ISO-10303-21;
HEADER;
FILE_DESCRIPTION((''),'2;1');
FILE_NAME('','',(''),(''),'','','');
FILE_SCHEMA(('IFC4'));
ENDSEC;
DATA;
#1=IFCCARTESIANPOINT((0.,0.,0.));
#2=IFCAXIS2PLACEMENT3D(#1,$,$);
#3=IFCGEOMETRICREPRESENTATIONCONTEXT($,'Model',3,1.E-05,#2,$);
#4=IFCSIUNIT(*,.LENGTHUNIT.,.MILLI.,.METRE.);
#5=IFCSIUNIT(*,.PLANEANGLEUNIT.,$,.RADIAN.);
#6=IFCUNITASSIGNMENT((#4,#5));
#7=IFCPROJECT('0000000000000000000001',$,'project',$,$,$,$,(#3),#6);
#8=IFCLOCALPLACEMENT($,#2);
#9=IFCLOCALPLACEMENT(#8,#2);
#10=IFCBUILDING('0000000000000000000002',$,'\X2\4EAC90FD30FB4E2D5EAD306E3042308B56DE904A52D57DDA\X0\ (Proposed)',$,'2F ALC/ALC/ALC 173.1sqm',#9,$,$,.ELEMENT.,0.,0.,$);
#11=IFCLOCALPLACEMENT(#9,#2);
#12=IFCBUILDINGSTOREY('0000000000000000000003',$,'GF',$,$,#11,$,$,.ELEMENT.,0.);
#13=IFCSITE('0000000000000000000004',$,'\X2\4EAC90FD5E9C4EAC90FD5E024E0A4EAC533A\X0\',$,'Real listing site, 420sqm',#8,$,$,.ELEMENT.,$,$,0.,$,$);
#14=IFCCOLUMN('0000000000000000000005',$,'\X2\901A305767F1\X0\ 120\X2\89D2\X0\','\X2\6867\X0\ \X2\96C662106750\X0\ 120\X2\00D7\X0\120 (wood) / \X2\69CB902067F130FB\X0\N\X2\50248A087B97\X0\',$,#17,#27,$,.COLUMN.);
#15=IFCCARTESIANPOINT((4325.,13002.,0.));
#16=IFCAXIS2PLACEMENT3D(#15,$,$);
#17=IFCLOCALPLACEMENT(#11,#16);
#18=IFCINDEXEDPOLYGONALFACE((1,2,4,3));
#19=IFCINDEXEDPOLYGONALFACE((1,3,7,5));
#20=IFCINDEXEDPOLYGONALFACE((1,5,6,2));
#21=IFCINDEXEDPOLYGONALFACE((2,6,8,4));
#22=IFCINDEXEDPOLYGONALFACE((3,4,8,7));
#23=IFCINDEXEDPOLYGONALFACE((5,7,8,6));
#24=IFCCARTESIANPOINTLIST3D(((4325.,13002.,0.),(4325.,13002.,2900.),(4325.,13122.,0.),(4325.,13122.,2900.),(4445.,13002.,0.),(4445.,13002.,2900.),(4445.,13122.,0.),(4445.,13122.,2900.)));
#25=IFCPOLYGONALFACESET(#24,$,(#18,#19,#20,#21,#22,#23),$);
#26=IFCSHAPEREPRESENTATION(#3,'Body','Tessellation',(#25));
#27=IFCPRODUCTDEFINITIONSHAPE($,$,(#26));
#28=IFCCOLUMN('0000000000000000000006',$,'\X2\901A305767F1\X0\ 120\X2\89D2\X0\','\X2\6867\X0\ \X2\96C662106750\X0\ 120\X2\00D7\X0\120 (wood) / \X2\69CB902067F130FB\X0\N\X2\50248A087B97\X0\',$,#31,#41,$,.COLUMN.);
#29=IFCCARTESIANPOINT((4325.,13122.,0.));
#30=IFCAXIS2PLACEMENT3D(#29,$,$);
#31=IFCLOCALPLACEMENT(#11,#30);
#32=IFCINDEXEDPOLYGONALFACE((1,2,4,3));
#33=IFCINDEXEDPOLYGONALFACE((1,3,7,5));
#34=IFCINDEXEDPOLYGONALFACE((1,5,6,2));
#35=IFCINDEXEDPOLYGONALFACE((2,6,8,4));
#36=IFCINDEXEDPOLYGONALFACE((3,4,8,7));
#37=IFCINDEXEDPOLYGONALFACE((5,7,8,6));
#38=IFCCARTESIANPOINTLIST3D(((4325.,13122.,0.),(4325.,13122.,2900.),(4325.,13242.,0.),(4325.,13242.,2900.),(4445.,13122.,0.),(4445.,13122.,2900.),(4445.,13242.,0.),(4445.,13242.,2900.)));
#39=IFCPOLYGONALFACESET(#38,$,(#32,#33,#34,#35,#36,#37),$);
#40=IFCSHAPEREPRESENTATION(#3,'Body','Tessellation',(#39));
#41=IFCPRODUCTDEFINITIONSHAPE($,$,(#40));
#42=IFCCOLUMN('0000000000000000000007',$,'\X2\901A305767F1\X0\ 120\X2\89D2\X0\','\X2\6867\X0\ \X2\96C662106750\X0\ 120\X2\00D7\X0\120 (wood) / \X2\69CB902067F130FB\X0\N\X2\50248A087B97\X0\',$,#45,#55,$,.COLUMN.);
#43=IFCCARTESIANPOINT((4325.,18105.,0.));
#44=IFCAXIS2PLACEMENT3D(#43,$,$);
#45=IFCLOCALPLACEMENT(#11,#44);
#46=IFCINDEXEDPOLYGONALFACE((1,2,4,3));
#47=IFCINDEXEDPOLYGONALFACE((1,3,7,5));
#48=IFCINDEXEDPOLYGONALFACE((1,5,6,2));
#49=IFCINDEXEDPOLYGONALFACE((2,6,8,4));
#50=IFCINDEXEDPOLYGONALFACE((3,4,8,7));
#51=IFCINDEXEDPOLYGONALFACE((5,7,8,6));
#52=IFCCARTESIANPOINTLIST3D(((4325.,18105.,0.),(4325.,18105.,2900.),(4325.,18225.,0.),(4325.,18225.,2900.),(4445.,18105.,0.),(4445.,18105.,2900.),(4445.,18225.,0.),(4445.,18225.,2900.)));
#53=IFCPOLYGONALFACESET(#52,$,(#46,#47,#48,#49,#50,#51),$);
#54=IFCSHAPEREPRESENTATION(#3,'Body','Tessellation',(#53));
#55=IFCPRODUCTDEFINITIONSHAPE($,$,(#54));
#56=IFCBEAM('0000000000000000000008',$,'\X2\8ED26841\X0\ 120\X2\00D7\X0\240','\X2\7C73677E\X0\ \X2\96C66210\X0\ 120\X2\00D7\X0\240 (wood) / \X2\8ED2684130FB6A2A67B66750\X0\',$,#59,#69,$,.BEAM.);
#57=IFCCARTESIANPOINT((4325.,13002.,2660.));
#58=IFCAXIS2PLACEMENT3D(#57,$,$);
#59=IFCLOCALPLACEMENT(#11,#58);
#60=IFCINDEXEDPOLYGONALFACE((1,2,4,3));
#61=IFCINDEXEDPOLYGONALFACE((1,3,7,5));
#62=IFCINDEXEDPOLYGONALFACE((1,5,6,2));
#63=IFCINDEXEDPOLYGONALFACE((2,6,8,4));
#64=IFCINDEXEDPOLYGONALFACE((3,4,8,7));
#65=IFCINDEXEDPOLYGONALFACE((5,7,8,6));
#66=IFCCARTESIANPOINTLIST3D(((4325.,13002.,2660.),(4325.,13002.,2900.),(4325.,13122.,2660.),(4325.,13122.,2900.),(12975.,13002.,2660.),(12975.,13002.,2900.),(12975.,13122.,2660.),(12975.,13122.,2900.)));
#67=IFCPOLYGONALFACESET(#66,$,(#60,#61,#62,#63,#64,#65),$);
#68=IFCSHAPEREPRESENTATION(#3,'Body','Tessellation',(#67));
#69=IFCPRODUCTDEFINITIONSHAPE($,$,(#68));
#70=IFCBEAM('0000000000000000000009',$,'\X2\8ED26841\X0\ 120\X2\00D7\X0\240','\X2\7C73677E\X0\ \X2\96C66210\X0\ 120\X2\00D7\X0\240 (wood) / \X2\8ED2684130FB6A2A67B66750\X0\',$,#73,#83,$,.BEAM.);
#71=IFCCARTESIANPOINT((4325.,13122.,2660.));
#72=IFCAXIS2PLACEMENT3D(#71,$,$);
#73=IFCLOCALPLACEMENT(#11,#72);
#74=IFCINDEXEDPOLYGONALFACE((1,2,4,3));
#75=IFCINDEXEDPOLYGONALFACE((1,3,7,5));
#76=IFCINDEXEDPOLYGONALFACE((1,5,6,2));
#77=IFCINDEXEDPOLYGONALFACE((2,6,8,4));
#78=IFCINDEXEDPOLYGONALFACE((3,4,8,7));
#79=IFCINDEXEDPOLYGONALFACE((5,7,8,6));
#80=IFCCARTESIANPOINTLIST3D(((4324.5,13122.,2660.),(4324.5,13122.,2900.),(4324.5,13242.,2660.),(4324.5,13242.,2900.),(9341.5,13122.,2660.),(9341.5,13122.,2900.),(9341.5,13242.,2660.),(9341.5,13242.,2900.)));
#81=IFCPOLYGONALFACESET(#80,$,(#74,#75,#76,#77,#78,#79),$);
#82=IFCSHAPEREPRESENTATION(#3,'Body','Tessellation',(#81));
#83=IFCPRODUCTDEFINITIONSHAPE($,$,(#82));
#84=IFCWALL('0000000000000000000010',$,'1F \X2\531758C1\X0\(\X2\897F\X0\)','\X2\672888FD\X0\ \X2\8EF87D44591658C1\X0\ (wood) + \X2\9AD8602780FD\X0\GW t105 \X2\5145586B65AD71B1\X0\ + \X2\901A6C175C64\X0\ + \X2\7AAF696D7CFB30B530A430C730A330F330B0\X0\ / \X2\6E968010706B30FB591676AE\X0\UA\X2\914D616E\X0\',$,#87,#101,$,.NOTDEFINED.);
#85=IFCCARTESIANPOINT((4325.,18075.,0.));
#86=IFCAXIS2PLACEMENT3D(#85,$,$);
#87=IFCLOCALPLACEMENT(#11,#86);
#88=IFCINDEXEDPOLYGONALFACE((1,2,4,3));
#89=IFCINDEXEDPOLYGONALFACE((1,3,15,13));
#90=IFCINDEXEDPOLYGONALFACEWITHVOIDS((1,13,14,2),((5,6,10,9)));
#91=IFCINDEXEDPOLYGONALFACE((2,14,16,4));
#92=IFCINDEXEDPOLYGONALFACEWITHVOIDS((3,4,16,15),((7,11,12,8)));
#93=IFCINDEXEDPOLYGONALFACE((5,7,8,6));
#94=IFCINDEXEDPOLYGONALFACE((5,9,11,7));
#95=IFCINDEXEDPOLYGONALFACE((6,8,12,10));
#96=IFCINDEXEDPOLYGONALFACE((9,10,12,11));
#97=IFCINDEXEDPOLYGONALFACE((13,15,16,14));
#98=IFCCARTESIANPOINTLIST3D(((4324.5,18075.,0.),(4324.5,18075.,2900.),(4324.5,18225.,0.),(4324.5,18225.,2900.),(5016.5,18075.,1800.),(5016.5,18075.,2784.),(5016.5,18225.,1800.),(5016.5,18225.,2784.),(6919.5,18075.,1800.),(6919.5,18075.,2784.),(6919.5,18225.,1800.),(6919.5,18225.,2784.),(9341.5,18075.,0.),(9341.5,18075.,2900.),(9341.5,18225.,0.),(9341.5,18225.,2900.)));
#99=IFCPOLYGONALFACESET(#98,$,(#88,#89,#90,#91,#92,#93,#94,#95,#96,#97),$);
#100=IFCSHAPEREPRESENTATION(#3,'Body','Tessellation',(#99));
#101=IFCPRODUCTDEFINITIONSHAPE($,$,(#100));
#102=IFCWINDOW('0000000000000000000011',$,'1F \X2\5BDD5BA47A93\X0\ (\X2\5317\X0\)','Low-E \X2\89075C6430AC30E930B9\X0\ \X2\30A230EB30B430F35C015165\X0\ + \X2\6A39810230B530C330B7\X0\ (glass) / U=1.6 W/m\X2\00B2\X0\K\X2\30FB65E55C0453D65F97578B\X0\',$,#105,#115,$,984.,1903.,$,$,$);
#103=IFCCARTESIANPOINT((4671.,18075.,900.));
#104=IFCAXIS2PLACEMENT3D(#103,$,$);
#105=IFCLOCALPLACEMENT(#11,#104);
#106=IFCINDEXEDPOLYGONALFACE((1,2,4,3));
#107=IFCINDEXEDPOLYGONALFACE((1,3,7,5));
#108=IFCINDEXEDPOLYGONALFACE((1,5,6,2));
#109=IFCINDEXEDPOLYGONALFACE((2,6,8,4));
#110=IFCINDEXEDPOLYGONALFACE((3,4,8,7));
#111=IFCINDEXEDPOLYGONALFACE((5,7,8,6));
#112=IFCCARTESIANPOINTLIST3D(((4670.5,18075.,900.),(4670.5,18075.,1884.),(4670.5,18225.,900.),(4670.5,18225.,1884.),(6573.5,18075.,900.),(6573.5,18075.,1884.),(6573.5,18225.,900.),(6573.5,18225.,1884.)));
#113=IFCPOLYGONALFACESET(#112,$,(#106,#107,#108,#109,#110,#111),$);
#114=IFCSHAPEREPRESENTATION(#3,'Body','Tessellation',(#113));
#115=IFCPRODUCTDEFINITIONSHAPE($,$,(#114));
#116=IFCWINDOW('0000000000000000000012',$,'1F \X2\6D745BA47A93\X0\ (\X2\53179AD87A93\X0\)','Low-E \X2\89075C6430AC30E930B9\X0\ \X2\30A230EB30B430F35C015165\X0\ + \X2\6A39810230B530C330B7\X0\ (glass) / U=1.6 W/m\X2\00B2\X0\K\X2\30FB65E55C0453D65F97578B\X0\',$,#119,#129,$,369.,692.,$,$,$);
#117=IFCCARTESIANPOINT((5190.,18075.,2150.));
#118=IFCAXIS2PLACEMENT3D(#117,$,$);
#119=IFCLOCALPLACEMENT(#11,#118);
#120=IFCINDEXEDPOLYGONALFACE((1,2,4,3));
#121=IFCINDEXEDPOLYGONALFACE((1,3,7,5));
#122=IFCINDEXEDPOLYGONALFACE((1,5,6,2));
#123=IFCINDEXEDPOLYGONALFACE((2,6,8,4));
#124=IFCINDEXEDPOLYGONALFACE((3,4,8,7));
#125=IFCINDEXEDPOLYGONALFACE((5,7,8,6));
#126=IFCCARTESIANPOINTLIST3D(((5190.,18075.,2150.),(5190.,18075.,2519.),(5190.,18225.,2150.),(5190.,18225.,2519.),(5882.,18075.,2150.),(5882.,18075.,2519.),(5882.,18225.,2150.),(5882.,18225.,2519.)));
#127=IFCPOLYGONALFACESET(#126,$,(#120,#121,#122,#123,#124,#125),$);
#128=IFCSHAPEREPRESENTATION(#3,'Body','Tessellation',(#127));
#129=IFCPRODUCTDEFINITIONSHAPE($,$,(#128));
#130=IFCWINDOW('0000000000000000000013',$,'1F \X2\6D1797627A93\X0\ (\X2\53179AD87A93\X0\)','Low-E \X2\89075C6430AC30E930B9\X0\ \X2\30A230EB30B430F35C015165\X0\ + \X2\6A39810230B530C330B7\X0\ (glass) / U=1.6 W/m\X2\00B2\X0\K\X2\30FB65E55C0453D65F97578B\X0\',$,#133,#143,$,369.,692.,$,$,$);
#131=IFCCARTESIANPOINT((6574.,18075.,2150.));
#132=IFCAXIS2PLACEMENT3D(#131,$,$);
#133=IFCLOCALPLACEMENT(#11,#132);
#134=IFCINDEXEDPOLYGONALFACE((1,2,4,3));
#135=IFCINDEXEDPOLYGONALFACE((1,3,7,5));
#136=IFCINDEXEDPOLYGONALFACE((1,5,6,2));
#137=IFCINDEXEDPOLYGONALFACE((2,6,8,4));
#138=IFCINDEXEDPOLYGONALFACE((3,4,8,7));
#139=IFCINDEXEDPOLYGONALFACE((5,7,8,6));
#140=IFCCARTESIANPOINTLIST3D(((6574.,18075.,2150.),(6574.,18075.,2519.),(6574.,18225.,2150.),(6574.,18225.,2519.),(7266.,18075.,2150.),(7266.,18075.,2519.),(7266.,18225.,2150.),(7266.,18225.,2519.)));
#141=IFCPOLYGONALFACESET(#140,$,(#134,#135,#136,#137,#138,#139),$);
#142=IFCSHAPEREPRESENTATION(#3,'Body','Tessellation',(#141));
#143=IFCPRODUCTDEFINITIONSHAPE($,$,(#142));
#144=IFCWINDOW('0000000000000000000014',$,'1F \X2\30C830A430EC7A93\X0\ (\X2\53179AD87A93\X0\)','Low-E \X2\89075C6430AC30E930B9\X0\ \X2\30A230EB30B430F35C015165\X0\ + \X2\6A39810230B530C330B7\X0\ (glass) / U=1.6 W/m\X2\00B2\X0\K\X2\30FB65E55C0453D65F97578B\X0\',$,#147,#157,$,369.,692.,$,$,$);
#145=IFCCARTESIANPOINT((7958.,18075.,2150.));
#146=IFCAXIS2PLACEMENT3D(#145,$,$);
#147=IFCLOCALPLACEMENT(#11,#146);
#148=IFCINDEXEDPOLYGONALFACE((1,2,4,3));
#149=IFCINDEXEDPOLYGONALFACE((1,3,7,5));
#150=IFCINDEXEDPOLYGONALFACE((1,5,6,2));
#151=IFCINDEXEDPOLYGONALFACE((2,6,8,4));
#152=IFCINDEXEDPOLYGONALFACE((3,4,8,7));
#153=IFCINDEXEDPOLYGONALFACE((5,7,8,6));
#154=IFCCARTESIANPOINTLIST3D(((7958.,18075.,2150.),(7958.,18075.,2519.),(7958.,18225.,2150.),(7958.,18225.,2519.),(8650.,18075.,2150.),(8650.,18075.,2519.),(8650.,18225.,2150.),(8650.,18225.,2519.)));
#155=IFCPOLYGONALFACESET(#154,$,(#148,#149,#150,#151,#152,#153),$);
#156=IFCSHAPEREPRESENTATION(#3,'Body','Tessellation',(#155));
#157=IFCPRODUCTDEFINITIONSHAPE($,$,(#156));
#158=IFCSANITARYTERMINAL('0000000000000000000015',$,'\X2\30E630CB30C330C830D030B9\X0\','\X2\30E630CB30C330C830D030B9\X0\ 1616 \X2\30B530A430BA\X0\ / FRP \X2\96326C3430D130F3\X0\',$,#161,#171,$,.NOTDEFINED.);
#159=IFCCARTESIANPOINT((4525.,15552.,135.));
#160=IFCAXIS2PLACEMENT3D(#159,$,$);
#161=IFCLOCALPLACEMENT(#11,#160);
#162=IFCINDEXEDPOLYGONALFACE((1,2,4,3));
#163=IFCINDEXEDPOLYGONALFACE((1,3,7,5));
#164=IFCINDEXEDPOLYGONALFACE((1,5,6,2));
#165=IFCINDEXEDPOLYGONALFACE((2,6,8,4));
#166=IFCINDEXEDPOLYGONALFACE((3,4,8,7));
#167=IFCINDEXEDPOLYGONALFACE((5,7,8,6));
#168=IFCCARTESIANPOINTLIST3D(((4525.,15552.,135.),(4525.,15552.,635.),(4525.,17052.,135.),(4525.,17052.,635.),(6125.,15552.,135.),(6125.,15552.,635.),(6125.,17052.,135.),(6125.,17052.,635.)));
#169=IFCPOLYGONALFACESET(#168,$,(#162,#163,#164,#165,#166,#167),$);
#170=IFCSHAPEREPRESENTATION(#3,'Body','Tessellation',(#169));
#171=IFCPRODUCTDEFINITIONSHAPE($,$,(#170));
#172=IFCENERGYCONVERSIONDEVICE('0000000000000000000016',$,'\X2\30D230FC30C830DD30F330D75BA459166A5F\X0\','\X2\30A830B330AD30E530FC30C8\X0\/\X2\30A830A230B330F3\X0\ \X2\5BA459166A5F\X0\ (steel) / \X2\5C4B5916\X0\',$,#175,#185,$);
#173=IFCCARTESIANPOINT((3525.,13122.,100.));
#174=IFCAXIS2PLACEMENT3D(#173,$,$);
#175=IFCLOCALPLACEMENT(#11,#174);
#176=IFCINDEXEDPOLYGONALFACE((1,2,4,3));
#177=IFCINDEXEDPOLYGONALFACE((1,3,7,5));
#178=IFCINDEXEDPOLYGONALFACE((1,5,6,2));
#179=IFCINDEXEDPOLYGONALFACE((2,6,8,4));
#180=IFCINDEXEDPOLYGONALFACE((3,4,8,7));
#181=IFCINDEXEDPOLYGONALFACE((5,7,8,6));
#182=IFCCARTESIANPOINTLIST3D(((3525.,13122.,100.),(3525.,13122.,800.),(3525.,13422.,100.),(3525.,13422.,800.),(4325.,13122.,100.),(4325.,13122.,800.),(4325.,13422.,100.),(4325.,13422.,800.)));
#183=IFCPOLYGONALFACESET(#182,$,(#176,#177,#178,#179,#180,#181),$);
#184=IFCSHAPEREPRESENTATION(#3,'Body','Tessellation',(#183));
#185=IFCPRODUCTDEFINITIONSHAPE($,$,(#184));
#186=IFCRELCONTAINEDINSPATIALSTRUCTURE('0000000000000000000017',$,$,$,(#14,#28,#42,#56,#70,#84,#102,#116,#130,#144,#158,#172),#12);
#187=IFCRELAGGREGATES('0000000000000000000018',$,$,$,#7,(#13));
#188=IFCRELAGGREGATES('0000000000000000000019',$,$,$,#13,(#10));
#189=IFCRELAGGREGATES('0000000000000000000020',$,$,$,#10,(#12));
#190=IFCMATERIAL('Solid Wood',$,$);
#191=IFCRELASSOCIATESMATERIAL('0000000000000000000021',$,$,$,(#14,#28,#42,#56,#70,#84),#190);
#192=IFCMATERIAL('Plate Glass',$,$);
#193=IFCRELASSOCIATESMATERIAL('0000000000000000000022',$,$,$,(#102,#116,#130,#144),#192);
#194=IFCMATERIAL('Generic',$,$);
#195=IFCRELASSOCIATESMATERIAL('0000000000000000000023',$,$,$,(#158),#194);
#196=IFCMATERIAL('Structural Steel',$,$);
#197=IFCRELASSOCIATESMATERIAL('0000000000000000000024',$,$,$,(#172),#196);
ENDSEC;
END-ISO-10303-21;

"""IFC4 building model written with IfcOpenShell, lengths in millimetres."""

from ifc_helpers import new_model, si_unit, frame, frame_2d, origin, place, context, project, spatial, rectangle, extrude, material, element, fill, save


model = new_model("IFC4")

# Units and contexts
model_context = context("Model", 3, precision=1e-05, world=origin())
ifc_project = project(units=[si_unit("LENGTHUNIT", "METRE", prefix="MILLI"), si_unit("PLANEANGLEUNIT", "RADIAN")], contexts=[model_context])

# Site, building, storey
site_placement = place(None, origin())
site = spatial("IfcSite", under=ifc_project, at=site_placement, Name="京都府京都市上京区", ObjectType="Real listing site, 420sqm", CompositionType="ELEMENT", RefElevation=0.0)
building_placement = place(site_placement, origin())
building = spatial("IfcBuilding", under=site, at=building_placement, Name="京都・中庭のある回遊動線 (Proposed)", ObjectType="2F ALC/ALC/ALC 173.1sqm", CompositionType="ELEMENT", ElevationOfRefHeight=0.0, ElevationOfTerrain=0.0)
storey_placement = place(building_placement, origin())
storey = spatial("IfcBuildingStorey", under=building, at=storey_placement, Name="GF", CompositionType="ELEMENT", Elevation=0.0)

# Columns
ifc_material_1 = material(Name="Solid Wood")
column_1_placement = place(storey_placement, frame((4325.0, 13002.0, 0.0)))
element("IfcColumn", 1, at=column_1_placement, inside=storey, material=ifc_material_1, Name="通し柱 120角", Description="桧 集成材 120×120 (wood) / 構造柱・N値計算", PredefinedType="COLUMN", context=model_context, shape_type="SweptSolid", body=[
    extrude(rectangle(XDim=120.0, YDim=120.0, at=frame_2d((60.0, 60.0))), frame((4325.0, 13002.0, 0.0)), (0.0, 0.0, 1.0), 2900.0),
])
column_2_placement = place(storey_placement, frame((4325.0, 13122.0, 0.0)))
element("IfcColumn", 2, at=column_2_placement, inside=storey, material=ifc_material_1, Name="通し柱 120角", Description="桧 集成材 120×120 (wood) / 構造柱・N値計算", PredefinedType="COLUMN", context=model_context, shape_type="SweptSolid", body=[
    extrude(rectangle(XDim=120.0, YDim=120.0, at=frame_2d((60.0, 60.0))), frame((4325.0, 13122.0, 0.0)), (0.0, 0.0, 1.0), 2900.0),
])
column_3_placement = place(storey_placement, frame((4325.0, 18105.0, 0.0)))
element("IfcColumn", 3, at=column_3_placement, inside=storey, material=ifc_material_1, Name="通し柱 120角", Description="桧 集成材 120×120 (wood) / 構造柱・N値計算", PredefinedType="COLUMN", context=model_context, shape_type="SweptSolid", body=[
    extrude(rectangle(XDim=120.0, YDim=120.0, at=frame_2d((60.0, 60.0))), frame((4325.0, 18105.0, 0.0)), (0.0, 0.0, 1.0), 2900.0),
])

# Beams
beam_1_placement = place(storey_placement, frame((4325.0, 13002.0, 2660.0)))
element("IfcBeam", 4, at=beam_1_placement, inside=storey, material=ifc_material_1, Name="軒桁 120×240", Description="米松 集成 120×240 (wood) / 軒桁・横架材", PredefinedType="BEAM", context=model_context, shape_type="SweptSolid", body=[
    extrude(rectangle(XDim=8650.0, YDim=120.0, at=frame_2d((4325.0, 60.0))), frame((4325.0, 13002.0, 2660.0)), (0.0, 0.0, 1.0), 240.0),
])
beam_2_placement = place(storey_placement, frame((4325.0, 13122.0, 2660.0)))
element("IfcBeam", 5, at=beam_2_placement, inside=storey, material=ifc_material_1, Name="軒桁 120×240", Description="米松 集成 120×240 (wood) / 軒桁・横架材", PredefinedType="BEAM", context=model_context, shape_type="SweptSolid", body=[
    extrude(rectangle(XDim=5017.0, YDim=120.0, at=frame_2d((2508.0, 60.0))), frame((4325.0, 13122.0, 2660.0)), (0.0, 0.0, 1.0), 240.0),
])

# Wall, openings, windows
wall_1_placement = place(storey_placement, frame((4325.0, 18075.0, 0.0)))
wall_1 = element("IfcWall", 6, at=wall_1_placement, inside=storey, material=ifc_material_1, Name="1F 北壁(西)", Description="木製 軸組外壁 (wood) + 高性能GW t105 充填断熱 + 通気層 + 窯業系サイディング / 準耐火・外皮UA配慮", PredefinedType="NOTDEFINED", context=model_context, shape_type="SweptSolid", body=[
    extrude(rectangle(XDim=5017.0, YDim=150.0, at=frame_2d((2508.0, 75.0))), frame((4325.0, 18075.0, 0.0)), (0.0, 0.0, 1.0), 2900.0),
])
opening_1_placement = place(storey_placement, frame((4671.0, 18075.0, 900.0)))
opening_1 = element("IfcOpeningElement", 7, at=opening_1_placement, cuts=wall_1, PredefinedType="NOTDEFINED", context=model_context, shape_type="SweptSolid", body=[
    extrude(rectangle(XDim=1903.0, YDim=150.0, at=frame_2d((951.0, 75.0))), frame((4671.0, 18075.0, 900.0)), (0.0, 0.0, 1.0), 984.0),
])
opening_2_placement = place(storey_placement, frame((5190.0, 18075.0, 2150.0)))
opening_2 = element("IfcOpeningElement", 8, at=opening_2_placement, cuts=wall_1, PredefinedType="NOTDEFINED", context=model_context, shape_type="SweptSolid", body=[
    extrude(rectangle(XDim=692.0, YDim=150.0, at=frame_2d((346.0, 75.0))), frame((5190.0, 18075.0, 2150.0)), (0.0, 0.0, 1.0), 369.0),
])
opening_3_placement = place(storey_placement, frame((6574.0, 18075.0, 2150.0)))
opening_3 = element("IfcOpeningElement", 9, at=opening_3_placement, cuts=wall_1, PredefinedType="NOTDEFINED", context=model_context, shape_type="SweptSolid", body=[
    extrude(rectangle(XDim=692.0, YDim=150.0, at=frame_2d((346.0, 75.0))), frame((6574.0, 18075.0, 2150.0)), (0.0, 0.0, 1.0), 369.0),
])
opening_4_placement = place(storey_placement, frame((7958.0, 18075.0, 2150.0)))
opening_4 = element("IfcOpeningElement", 10, at=opening_4_placement, cuts=wall_1, PredefinedType="NOTDEFINED", context=model_context, shape_type="SweptSolid", body=[
    extrude(rectangle(XDim=692.0, YDim=150.0, at=frame_2d((346.0, 75.0))), frame((7958.0, 18075.0, 2150.0)), (0.0, 0.0, 1.0), 369.0),
])
ifc_material_2 = material(Name="Plate Glass")
window_1_placement = place(storey_placement, frame((4671.0, 18075.0, 900.0)))
window_1 = element("IfcWindow", 11, at=window_1_placement, inside=storey, material=ifc_material_2, Name="1F 寝室窓 (北)", Description="Low-E 複層ガラス アルゴン封入 + 樹脂サッシ (glass) / U=1.6 W/m²K・日射取得型", OverallHeight=984.0, OverallWidth=1903.0, context=model_context, shape_type="SweptSolid", body=[
    extrude(rectangle(XDim=1903.0, YDim=150.0, at=frame_2d((951.0, 75.0))), frame((4671.0, 18075.0, 900.0)), (0.0, 0.0, 1.0), 984.0),
])
fill(opening_1, window_1)
window_2_placement = place(storey_placement, frame((5190.0, 18075.0, 2150.0)))
window_2 = element("IfcWindow", 12, at=window_2_placement, inside=storey, material=ifc_material_2, Name="1F 浴室窓 (北高窓)", Description="Low-E 複層ガラス アルゴン封入 + 樹脂サッシ (glass) / U=1.6 W/m²K・日射取得型", OverallHeight=369.0, OverallWidth=692.0, context=model_context, shape_type="SweptSolid", body=[
    extrude(rectangle(XDim=692.0, YDim=150.0, at=frame_2d((346.0, 75.0))), frame((5190.0, 18075.0, 2150.0)), (0.0, 0.0, 1.0), 369.0),
])
fill(opening_2, window_2)
window_3_placement = place(storey_placement, frame((6574.0, 18075.0, 2150.0)))
window_3 = element("IfcWindow", 13, at=window_3_placement, inside=storey, material=ifc_material_2, Name="1F 洗面窓 (北高窓)", Description="Low-E 複層ガラス アルゴン封入 + 樹脂サッシ (glass) / U=1.6 W/m²K・日射取得型", OverallHeight=369.0, OverallWidth=692.0, context=model_context, shape_type="SweptSolid", body=[
    extrude(rectangle(XDim=692.0, YDim=150.0, at=frame_2d((346.0, 75.0))), frame((6574.0, 18075.0, 2150.0)), (0.0, 0.0, 1.0), 369.0),
])
fill(opening_3, window_3)
window_4_placement = place(storey_placement, frame((7958.0, 18075.0, 2150.0)))
window_4 = element("IfcWindow", 14, at=window_4_placement, inside=storey, material=ifc_material_2, Name="1F トイレ窓 (北高窓)", Description="Low-E 複層ガラス アルゴン封入 + 樹脂サッシ (glass) / U=1.6 W/m²K・日射取得型", OverallHeight=369.0, OverallWidth=692.0, context=model_context, shape_type="SweptSolid", body=[
    extrude(rectangle(XDim=692.0, YDim=150.0, at=frame_2d((346.0, 75.0))), frame((7958.0, 18075.0, 2150.0)), (0.0, 0.0, 1.0), 369.0),
])
fill(opening_4, window_4)

# Shared definitions
ifc_material_3 = material(Name="Generic")

# Sanitary terminal
sanitary_terminal_placement = place(storey_placement, frame((4525.0, 15552.0, 135.0)))
element("IfcSanitaryTerminal", 15, at=sanitary_terminal_placement, inside=storey, material=ifc_material_3, Name="ユニットバス", Description="ユニットバス 1616 サイズ / FRP 防水パン", PredefinedType="NOTDEFINED", context=model_context, shape_type="SweptSolid", body=[
    extrude(rectangle(XDim=1600.0, YDim=1500.0, at=frame_2d((800.0, 750.0))), frame((4525.0, 15552.0, 135.0)), (0.0, 0.0, 1.0), 500.0),
])

# Energy conversion device
ifc_material_4 = material(Name="Structural Steel")
energy_conversion_device_placement = place(storey_placement, frame((3525.0, 13122.0, 100.0)))
element("IfcEnergyConversionDevice", 16, at=energy_conversion_device_placement, inside=storey, material=ifc_material_4, Name="ヒートポンプ室外機", Description="エコキュート/エアコン 室外機 (steel) / 屋外", context=model_context, shape_type="SweptSolid", body=[
    extrude(rectangle(XDim=800.0, YDim=300.0, at=frame_2d((400.0, 150.0))), frame((3525.0, 13122.0, 100.0)), (0.0, 0.0, 1.0), 700.0),
])

save(model, "model.ifc")
